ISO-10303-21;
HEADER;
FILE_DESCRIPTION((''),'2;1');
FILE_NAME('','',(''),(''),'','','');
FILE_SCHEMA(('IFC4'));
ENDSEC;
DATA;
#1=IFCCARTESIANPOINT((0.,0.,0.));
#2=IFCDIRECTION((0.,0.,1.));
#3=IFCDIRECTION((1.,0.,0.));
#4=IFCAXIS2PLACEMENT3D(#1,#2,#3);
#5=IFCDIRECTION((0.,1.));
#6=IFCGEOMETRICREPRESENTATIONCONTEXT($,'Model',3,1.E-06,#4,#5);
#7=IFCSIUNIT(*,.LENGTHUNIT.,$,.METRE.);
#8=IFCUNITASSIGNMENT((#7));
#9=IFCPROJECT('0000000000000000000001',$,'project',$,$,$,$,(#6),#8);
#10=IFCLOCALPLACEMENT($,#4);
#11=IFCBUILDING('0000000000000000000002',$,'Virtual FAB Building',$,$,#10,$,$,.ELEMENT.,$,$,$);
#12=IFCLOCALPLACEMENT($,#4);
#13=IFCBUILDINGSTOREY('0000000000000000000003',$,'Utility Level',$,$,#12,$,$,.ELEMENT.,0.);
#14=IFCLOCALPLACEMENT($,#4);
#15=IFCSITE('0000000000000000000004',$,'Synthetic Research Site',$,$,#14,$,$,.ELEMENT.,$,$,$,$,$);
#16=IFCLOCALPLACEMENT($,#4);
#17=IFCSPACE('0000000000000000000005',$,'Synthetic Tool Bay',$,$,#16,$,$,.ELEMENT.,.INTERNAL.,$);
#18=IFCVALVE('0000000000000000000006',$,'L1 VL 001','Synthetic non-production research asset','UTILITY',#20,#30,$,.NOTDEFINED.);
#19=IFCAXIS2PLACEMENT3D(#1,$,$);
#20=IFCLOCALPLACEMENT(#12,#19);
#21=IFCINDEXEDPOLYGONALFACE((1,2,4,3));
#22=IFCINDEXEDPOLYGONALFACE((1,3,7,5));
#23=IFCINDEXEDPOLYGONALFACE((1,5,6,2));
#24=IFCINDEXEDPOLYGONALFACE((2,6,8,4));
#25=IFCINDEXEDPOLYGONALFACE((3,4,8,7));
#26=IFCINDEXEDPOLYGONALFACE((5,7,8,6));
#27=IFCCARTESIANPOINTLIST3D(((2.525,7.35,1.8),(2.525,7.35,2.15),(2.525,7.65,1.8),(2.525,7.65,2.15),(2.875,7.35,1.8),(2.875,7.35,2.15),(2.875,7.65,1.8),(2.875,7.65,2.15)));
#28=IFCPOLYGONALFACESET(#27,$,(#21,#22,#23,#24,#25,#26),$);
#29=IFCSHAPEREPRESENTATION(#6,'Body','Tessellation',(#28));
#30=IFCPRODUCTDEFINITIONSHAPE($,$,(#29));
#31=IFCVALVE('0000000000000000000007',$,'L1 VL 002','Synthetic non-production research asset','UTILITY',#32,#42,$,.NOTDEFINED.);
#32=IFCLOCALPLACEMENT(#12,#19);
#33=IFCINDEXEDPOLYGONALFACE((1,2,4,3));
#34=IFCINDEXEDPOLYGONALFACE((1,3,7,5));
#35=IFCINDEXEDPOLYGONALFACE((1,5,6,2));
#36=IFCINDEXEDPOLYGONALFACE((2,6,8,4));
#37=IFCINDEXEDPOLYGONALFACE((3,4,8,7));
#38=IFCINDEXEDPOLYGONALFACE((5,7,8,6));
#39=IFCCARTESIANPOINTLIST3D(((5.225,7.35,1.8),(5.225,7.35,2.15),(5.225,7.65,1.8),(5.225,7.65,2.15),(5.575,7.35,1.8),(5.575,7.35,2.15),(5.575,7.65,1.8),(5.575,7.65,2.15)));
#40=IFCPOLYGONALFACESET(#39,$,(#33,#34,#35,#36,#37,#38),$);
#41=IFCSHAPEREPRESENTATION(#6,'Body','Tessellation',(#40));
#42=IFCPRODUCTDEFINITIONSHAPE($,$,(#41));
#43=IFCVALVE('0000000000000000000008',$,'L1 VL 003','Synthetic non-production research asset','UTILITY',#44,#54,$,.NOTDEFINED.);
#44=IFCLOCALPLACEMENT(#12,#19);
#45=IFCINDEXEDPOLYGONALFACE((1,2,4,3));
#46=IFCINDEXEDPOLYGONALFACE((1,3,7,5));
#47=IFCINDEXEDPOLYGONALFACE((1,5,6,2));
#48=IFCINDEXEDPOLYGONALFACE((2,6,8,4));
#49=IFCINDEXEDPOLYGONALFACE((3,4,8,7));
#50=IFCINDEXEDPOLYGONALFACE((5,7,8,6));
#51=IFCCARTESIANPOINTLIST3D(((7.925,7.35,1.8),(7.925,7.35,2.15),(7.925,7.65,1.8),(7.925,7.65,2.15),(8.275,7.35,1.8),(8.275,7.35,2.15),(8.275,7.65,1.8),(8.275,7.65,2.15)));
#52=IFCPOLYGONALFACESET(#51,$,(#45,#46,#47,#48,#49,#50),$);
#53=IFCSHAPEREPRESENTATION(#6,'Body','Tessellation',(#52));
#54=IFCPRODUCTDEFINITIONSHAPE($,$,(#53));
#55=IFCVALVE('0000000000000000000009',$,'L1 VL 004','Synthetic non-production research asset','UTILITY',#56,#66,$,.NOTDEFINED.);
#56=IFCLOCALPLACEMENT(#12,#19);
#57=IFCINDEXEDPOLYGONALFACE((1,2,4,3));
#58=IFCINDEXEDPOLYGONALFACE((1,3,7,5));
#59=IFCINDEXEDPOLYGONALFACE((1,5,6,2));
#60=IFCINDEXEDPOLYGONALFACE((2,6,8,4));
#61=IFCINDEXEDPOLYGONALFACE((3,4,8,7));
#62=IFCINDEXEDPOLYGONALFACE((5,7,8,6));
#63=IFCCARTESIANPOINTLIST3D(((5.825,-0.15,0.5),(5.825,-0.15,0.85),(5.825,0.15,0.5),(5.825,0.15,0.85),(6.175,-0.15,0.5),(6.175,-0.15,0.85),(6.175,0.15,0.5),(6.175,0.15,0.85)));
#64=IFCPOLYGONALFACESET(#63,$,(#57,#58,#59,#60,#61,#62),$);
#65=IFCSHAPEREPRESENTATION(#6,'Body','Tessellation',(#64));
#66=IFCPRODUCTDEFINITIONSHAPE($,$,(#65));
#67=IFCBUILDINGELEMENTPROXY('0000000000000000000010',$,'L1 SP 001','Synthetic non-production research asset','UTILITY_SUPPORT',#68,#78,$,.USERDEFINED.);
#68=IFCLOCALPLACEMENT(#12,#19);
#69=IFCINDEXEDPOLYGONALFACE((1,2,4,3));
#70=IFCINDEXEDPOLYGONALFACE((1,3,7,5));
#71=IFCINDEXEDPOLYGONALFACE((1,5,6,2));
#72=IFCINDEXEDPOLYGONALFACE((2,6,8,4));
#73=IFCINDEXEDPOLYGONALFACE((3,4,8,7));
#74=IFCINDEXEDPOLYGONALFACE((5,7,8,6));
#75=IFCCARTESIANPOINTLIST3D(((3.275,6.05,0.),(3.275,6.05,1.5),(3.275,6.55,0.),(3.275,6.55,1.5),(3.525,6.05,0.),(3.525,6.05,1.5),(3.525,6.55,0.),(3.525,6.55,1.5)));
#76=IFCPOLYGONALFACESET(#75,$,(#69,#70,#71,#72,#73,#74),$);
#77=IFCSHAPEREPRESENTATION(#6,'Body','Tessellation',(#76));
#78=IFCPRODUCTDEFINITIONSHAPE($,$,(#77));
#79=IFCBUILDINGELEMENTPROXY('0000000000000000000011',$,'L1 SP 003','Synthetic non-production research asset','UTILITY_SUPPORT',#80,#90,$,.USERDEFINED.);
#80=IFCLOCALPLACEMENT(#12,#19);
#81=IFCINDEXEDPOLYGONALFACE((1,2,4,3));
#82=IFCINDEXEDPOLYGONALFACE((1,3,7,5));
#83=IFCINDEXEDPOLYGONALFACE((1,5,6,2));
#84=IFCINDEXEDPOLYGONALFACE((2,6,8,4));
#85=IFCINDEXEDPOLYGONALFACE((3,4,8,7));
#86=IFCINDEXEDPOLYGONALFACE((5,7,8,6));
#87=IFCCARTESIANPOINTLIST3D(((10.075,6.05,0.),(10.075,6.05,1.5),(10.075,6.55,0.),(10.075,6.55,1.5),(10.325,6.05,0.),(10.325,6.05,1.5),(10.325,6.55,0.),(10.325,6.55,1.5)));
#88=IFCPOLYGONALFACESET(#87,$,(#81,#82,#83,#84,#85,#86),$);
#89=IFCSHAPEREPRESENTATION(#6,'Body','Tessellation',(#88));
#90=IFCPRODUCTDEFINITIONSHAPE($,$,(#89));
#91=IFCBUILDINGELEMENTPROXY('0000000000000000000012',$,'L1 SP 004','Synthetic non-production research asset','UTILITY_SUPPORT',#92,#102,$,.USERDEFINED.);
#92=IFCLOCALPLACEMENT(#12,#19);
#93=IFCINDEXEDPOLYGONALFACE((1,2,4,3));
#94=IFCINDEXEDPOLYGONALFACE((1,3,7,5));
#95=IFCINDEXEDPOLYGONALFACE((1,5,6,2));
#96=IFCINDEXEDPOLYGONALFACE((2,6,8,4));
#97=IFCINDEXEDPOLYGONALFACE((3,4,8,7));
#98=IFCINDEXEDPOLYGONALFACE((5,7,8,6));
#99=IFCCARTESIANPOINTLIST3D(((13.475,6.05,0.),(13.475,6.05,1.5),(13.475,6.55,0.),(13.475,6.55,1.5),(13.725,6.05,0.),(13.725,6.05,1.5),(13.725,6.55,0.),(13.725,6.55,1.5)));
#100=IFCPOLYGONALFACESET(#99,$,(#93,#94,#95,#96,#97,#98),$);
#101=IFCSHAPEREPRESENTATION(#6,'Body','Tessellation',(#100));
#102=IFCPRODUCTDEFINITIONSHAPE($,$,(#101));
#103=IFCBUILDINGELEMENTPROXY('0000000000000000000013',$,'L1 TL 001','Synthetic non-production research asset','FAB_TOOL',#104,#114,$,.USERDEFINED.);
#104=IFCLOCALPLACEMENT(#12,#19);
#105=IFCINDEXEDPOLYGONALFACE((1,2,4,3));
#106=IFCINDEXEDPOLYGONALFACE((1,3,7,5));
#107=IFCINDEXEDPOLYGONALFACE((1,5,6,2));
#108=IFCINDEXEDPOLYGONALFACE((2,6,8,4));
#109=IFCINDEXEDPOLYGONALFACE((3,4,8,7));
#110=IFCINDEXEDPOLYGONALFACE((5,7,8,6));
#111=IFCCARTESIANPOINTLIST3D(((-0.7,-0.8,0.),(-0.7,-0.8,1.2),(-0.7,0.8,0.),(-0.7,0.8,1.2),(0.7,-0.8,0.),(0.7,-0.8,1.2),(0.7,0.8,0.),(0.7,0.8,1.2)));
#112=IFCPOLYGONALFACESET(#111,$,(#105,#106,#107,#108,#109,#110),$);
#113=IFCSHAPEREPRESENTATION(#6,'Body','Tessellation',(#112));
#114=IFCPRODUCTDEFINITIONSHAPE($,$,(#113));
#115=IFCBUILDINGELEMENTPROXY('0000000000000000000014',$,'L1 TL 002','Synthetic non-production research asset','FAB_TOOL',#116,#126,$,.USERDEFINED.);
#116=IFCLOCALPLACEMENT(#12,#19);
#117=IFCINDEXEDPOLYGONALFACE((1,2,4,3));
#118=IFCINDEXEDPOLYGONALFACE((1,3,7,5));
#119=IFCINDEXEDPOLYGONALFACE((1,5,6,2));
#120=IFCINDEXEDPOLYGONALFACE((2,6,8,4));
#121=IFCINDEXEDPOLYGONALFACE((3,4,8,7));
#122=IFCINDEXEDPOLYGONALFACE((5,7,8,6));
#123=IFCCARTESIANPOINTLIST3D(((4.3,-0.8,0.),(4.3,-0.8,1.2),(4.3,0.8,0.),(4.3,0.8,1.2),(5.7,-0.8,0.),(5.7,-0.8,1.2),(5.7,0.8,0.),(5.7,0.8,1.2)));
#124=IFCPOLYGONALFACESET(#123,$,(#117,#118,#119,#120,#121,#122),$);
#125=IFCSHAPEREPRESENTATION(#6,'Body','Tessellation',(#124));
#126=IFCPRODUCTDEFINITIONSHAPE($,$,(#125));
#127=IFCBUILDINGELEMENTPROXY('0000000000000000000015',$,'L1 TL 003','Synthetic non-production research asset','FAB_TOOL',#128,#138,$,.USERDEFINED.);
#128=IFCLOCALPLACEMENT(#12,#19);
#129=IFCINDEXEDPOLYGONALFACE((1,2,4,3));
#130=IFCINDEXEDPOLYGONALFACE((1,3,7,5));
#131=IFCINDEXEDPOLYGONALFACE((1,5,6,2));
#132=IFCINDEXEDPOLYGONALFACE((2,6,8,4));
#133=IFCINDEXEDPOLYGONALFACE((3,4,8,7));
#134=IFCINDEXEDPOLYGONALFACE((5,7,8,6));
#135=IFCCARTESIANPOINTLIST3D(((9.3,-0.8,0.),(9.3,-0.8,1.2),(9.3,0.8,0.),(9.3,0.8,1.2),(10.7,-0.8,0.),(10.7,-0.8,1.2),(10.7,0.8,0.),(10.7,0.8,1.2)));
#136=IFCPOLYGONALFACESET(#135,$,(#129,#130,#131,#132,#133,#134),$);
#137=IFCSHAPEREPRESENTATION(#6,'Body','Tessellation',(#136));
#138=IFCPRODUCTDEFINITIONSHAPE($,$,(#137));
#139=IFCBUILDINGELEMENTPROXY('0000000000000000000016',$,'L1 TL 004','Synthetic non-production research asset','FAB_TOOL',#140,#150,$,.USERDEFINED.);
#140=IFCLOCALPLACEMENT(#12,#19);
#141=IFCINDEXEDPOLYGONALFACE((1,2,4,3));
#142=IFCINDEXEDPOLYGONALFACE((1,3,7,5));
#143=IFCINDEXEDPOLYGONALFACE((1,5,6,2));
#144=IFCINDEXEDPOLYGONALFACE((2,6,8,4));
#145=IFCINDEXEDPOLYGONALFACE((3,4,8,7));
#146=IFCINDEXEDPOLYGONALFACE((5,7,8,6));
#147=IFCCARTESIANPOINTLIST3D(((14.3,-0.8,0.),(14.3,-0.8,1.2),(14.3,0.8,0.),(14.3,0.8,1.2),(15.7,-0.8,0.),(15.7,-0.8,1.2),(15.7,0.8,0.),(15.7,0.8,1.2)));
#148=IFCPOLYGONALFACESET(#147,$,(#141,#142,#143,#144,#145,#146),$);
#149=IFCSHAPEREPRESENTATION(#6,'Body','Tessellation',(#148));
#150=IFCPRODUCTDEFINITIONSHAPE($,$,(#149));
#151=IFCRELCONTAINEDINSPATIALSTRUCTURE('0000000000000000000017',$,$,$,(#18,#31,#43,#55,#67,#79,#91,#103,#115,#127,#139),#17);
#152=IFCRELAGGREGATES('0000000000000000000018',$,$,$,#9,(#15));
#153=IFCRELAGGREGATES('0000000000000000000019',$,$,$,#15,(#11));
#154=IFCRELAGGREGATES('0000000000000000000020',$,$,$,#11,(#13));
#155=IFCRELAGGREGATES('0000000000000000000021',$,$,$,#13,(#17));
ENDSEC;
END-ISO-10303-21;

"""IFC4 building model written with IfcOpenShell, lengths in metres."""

from ifc_helpers import new_model, si_unit, direction, frame, origin_with_axes, origin_2d_with_axis, place, context, project, spatial, rectangle, extrude, element, save


model = new_model("IFC4")

# Units and contexts
model_context = context("Model", 3, precision=1e-06, world=origin_with_axes(), true_north=direction((0.0, 1.0)))
ifc_project = project(units=[si_unit("LENGTHUNIT", "METRE")], contexts=[model_context])

# Site, building, storey, space
site_placement = place(None, origin_with_axes())
site = spatial("IfcSite", under=ifc_project, at=site_placement, Name="Synthetic Research Site", CompositionType="ELEMENT")
building_placement = place(None, origin_with_axes())
building = spatial("IfcBuilding", under=site, at=building_placement, Name="Virtual FAB Building", CompositionType="ELEMENT")
storey_placement = place(None, origin_with_axes())
storey = spatial("IfcBuildingStorey", under=building, at=storey_placement, Name="Utility Level", CompositionType="ELEMENT", Elevation=0.0)
space_placement = place(None, origin_with_axes())
space = spatial("IfcSpace", under=storey, at=space_placement, Name="Synthetic Tool Bay", CompositionType="ELEMENT", PredefinedType="INTERNAL")

# Valves
for number, where, z_axis, x_axis, name in (
    (1, (2.7, 7.5, 1.8), (0.0, 0.0, 1.0), (1.0, 0.0, 0.0), "L1 VL 001"),
    (2, (5.4, 7.5, 1.8), (0.0, 0.0, 1.0), (1.0, 0.0, 0.0), "L1 VL 002"),
    (3, (8.1, 7.5, 1.8), (0.0, 0.0, 1.0), (1.0, 0.0, 0.0), "L1 VL 003"),
    (4, (6.0, 0.0, 0.5), (0.0, 0.0, 1.0), (1.0, 0.0, 0.0), "L1 VL 004"),
):
    element("IfcValve", number, at=place(None, frame(where, z_axis=z_axis, x_axis=x_axis)), inside=space, Name=name, Description="Synthetic non-production research asset", ObjectType="UTILITY", PredefinedType="NOTDEFINED", context=model_context, shape_type="SweptSolid", body=[
        extrude(rectangle(XDim=0.35, YDim=0.3, at=origin_2d_with_axis()), origin_with_axes(), (0.0, 0.0, 1.0), 0.35),
    ])

# Building element proxies
for number, where, z_axis, x_axis, name in (
    (5, (3.4, 6.3, 0.0), (0.0, 0.0, 1.0), (1.0, 0.0, 0.0), "L1 SP 001"),
    (6, (10.2, 6.3, 0.0), (0.0, 0.0, 1.0), (1.0, 0.0, 0.0), "L1 SP 003"),
    (7, (13.6, 6.3, 0.0), (0.0, 0.0, 1.0), (1.0, 0.0, 0.0), "L1 SP 004"),
):
    element("IfcBuildingElementProxy", number, at=place(None, frame(where, z_axis=z_axis, x_axis=x_axis)), inside=space, Name=name, Description="Synthetic non-production research asset", ObjectType="UTILITY_SUPPORT", PredefinedType="USERDEFINED", context=model_context, shape_type="SweptSolid", body=[
        extrude(rectangle(XDim=0.25, YDim=0.5, at=origin_2d_with_axis()), origin_with_axes(), (0.0, 0.0, 1.0), 1.5),
    ])
for number, where, z_axis, x_axis, name in (
    (8, (0.0, 0.0, 0.0), (0.0, 0.0, 1.0), (1.0, 0.0, 0.0), "L1 TL 001"),
    (9, (5.0, 0.0, 0.0), (0.0, 0.0, 1.0), (1.0, 0.0, 0.0), "L1 TL 002"),
    (10, (10.0, 0.0, 0.0), (0.0, 0.0, 1.0), (1.0, 0.0, 0.0), "L1 TL 003"),
    (11, (15.0, 0.0, 0.0), (0.0, 0.0, 1.0), (1.0, 0.0, 0.0), "L1 TL 004"),
):
    element("IfcBuildingElementProxy", number, at=place(None, frame(where, z_axis=z_axis, x_axis=x_axis)), inside=space, Name=name, Description="Synthetic non-production research asset", ObjectType="FAB_TOOL", PredefinedType="USERDEFINED", context=model_context, shape_type="SweptSolid", body=[
        extrude(rectangle(XDim=1.4, YDim=1.6, at=origin_2d_with_axis()), origin_with_axes(), (0.0, 0.0, 1.0), 1.2),
    ])

save(model, "model.ifc")
